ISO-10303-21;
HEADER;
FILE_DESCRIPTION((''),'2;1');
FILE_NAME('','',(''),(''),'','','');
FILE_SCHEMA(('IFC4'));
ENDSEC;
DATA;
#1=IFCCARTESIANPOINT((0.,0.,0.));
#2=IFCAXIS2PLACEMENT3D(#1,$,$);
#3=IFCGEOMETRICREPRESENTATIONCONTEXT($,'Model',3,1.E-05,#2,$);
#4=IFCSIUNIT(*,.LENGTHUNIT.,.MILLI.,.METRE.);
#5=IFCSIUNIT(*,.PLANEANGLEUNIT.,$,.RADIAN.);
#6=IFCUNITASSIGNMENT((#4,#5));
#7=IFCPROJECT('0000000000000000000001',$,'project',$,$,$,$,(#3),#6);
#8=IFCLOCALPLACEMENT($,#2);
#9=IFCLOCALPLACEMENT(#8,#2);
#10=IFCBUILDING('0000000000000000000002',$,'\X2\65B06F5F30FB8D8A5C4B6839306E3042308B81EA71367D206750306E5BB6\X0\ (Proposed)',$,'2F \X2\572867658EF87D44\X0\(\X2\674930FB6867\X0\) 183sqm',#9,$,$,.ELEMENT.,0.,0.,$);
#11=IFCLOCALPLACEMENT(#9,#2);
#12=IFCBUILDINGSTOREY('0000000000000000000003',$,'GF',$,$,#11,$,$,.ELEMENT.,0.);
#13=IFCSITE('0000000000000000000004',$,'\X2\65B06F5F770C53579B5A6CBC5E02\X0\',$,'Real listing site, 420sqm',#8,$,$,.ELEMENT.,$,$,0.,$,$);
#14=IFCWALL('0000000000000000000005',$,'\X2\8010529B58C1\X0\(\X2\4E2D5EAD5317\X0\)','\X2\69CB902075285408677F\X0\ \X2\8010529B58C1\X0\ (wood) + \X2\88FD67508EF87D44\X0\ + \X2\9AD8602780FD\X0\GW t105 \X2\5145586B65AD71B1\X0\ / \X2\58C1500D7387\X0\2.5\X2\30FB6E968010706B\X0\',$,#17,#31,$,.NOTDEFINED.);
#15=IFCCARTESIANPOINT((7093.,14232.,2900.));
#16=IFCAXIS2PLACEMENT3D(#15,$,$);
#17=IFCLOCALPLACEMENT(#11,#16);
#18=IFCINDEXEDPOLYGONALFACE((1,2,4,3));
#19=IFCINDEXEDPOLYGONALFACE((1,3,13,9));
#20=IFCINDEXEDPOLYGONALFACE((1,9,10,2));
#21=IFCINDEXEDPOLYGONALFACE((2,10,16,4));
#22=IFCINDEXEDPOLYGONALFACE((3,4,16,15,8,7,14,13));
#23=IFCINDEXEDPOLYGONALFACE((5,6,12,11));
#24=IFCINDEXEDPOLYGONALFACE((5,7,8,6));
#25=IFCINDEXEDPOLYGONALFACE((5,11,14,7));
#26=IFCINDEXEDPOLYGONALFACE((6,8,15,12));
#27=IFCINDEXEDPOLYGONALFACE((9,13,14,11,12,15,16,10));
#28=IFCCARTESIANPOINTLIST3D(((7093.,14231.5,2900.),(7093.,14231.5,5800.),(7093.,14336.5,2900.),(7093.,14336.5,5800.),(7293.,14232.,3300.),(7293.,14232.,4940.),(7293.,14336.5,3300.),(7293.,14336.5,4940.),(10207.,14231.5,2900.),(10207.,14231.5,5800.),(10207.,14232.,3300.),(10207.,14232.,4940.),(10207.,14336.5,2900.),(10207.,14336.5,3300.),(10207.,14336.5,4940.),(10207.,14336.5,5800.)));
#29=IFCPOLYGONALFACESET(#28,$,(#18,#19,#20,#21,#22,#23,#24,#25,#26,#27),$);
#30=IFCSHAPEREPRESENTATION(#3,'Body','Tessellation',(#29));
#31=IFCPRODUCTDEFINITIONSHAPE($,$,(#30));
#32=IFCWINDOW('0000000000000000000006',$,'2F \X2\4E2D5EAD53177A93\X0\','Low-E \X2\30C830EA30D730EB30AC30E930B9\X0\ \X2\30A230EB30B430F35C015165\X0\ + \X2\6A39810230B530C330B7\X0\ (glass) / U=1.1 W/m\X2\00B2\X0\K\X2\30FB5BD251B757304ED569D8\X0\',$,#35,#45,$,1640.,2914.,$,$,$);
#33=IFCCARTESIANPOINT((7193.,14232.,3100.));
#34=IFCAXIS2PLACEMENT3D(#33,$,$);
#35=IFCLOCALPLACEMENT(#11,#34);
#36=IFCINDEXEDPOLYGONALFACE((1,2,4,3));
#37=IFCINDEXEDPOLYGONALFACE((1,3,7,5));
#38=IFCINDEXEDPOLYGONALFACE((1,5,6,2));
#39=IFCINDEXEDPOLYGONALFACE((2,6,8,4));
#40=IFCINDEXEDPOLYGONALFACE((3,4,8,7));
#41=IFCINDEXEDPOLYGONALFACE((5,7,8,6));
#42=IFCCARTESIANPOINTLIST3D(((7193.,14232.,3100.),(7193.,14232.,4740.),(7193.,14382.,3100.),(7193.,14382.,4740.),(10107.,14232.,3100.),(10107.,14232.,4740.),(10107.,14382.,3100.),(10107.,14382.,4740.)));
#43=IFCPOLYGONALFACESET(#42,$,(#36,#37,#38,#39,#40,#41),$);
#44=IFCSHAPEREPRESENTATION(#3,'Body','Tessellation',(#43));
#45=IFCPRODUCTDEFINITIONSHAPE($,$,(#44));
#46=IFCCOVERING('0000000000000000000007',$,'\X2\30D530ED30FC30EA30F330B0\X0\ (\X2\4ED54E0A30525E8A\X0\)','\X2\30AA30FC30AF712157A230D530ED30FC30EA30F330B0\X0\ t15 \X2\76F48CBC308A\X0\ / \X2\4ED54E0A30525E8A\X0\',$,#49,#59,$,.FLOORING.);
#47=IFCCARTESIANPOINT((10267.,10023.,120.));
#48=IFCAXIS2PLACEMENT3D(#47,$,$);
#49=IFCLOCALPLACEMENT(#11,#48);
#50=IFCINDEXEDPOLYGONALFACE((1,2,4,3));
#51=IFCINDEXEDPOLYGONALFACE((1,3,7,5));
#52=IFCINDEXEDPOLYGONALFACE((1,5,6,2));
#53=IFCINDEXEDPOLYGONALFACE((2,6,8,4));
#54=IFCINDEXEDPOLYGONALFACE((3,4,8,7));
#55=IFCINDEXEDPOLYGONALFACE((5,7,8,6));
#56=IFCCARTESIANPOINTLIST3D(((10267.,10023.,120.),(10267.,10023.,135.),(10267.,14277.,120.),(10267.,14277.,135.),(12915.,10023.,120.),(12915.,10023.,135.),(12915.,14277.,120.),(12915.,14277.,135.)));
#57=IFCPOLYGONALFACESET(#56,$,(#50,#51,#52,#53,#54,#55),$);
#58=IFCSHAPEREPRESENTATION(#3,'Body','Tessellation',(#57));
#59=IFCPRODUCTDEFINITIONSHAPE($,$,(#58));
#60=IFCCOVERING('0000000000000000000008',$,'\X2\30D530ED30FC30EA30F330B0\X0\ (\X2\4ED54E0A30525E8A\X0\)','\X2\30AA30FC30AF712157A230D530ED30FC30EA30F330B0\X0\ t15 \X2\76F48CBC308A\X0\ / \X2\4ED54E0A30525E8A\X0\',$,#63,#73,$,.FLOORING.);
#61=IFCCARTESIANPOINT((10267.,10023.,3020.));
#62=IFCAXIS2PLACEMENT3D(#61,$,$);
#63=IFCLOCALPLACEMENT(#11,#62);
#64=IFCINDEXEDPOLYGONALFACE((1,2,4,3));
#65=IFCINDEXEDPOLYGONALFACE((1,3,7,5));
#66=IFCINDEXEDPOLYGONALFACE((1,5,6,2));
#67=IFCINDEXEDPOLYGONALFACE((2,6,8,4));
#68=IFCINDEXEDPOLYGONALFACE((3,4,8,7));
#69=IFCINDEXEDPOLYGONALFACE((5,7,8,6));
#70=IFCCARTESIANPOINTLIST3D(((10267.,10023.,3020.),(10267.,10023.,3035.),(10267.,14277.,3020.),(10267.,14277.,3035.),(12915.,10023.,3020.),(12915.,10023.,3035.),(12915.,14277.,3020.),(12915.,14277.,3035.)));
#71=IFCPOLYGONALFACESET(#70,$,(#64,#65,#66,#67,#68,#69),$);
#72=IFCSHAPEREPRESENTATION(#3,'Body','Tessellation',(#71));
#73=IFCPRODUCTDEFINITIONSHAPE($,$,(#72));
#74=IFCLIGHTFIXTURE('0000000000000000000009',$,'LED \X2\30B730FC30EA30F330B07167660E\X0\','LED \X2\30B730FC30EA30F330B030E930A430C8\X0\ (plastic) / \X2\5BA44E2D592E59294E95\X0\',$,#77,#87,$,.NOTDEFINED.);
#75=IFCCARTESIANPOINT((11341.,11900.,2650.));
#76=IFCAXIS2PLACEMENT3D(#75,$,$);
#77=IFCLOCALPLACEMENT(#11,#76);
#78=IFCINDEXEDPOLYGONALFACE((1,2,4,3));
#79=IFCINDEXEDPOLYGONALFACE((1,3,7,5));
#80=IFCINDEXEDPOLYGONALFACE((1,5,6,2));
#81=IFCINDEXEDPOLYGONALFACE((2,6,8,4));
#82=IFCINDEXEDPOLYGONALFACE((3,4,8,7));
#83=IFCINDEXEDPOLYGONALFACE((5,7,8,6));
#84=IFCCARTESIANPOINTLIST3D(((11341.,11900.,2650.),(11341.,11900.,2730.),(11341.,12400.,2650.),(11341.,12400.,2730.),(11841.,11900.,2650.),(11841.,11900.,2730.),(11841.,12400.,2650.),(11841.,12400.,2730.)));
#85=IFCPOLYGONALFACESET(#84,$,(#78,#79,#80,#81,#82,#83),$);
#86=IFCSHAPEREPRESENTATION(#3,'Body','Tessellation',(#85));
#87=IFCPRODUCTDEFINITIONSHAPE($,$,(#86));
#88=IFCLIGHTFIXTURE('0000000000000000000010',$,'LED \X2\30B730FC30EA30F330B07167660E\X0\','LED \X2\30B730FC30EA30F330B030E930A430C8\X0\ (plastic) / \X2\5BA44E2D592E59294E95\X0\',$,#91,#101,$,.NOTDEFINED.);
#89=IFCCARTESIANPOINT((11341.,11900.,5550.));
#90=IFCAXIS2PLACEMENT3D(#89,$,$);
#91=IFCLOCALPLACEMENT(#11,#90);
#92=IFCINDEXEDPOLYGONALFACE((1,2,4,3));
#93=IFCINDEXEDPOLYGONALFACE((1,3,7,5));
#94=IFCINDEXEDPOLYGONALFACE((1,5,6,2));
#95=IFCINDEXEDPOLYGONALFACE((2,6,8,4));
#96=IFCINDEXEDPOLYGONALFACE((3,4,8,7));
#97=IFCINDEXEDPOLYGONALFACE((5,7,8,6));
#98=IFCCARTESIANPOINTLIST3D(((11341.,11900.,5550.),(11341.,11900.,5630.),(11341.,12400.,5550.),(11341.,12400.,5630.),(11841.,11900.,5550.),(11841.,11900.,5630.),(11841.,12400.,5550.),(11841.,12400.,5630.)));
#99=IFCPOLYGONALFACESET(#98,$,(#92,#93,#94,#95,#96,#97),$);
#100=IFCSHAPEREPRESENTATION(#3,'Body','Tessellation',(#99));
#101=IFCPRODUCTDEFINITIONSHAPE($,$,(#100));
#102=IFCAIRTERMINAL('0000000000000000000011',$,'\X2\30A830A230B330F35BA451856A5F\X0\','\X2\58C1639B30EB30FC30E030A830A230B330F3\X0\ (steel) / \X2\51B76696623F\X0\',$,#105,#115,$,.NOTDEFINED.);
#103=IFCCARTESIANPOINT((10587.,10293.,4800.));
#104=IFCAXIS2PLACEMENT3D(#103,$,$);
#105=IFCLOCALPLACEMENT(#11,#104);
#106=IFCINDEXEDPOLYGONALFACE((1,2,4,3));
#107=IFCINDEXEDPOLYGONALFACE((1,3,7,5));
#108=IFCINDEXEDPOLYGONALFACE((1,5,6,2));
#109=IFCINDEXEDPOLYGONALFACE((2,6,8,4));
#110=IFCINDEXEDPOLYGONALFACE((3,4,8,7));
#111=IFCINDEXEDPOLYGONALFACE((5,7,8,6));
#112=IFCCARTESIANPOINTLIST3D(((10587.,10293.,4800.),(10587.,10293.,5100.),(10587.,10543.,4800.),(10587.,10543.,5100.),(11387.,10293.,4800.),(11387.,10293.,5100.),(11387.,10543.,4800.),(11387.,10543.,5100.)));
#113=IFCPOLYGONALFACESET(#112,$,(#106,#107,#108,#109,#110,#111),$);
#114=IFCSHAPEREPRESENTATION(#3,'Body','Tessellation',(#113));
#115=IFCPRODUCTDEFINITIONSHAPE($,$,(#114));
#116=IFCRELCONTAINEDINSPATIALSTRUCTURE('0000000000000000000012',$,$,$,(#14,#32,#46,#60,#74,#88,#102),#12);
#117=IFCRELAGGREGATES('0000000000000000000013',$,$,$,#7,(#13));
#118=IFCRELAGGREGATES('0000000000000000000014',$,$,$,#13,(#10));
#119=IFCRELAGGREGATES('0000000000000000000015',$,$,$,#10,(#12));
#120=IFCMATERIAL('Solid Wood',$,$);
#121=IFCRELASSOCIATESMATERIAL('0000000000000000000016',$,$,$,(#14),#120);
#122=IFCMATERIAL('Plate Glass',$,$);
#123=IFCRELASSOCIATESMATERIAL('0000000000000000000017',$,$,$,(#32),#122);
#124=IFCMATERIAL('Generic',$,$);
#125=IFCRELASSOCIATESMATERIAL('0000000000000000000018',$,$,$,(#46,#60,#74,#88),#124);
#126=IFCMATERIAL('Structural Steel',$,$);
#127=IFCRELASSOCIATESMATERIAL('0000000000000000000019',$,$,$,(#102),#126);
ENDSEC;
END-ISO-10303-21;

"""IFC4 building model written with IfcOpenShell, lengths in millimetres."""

from ifc_helpers import new_model, si_unit, frame, frame_2d, origin, place, context, project, spatial, rectangle, extrude, material, element, fill, save


model = new_model("IFC4")

# Units and contexts
model_context = context("Model", 3, precision=1e-05, world=origin())
ifc_project = project(units=[si_unit("LENGTHUNIT", "METRE", prefix="MILLI"), si_unit("PLANEANGLEUNIT", "RADIAN")], contexts=[model_context])

# Site, building, storey
site_placement = place(None, origin())
site = spatial("IfcSite", under=ifc_project, at=site_placement, Name="新潟県南魚沼市", ObjectType="Real listing site, 420sqm", CompositionType="ELEMENT", RefElevation=0.0)
building_placement = place(site_placement, origin())
building = spatial("IfcBuilding", under=site, at=building_placement, Name="新潟・越屋根のある自然素材の家 (Proposed)", ObjectType="2F 在来軸組(杉・桧) 183sqm", CompositionType="ELEMENT", ElevationOfRefHeight=0.0, ElevationOfTerrain=0.0)
storey_placement = place(building_placement, origin())
storey = spatial("IfcBuildingStorey", under=building, at=storey_placement, Name="GF", CompositionType="ELEMENT", Elevation=0.0)

# Shared definitions
ifc_material_1 = material(Name="Solid Wood")

# Wall, opening, window
ifc_material_2 = material(Name="Plate Glass")
wall_1_placement = place(storey_placement, frame((7093.0, 14232.0, 2900.0)))
wall_1 = element("IfcWall", 1, at=wall_1_placement, inside=storey, material=ifc_material_1, Name="耐力壁(中庭北)", Description="構造用合板 耐力壁 (wood) + 製材軸組 + 高性能GW t105 充填断熱 / 壁倍率2.5・準耐火", PredefinedType="NOTDEFINED", context=model_context, shape_type="SweptSolid", body=[
    extrude(rectangle(XDim=3114.0, YDim=105.0, at=frame_2d((1557.0, 52.0))), frame((7093.0, 14232.0, 2900.0)), (0.0, 0.0, 1.0), 2900.0),
])
opening_1_placement = place(storey_placement, frame((7193.0, 14232.0, 3100.0)))
opening_1 = element("IfcOpeningElement", 2, at=opening_1_placement, cuts=wall_1, PredefinedType="NOTDEFINED", context=model_context, shape_type="SweptSolid", body=[
    extrude(rectangle(XDim=2914.0, YDim=150.0, at=frame_2d((1457.0, 75.0))), frame((7193.0, 14232.0, 3100.0)), (0.0, 0.0, 1.0), 1640.0),
])
window_1_placement = place(storey_placement, frame((7193.0, 14232.0, 3100.0)))
window_1 = element("IfcWindow", 3, at=window_1_placement, inside=storey, material=ifc_material_2, Name="2F 中庭北窓", Description="Low-E トリプルガラス アルゴン封入 + 樹脂サッシ (glass) / U=1.1 W/m²K・寒冷地仕様", OverallHeight=1640.0, OverallWidth=2914.0, context=model_context, shape_type="SweptSolid", body=[
    extrude(rectangle(XDim=2914.0, YDim=150.0, at=frame_2d((1457.0, 75.0))), frame((7193.0, 14232.0, 3100.0)), (0.0, 0.0, 1.0), 1640.0),
])
fill(opening_1, window_1)

# Coverings
ifc_material_3 = material(Name="Generic")
covering_1_placement = place(storey_placement, frame((10267.0, 10023.0, 120.0)))
element("IfcCovering", 4, at=covering_1_placement, inside=storey, material=ifc_material_3, Name="フローリング (仕上げ床)", Description="オーク無垢フローリング t15 直貼り / 仕上げ床", PredefinedType="FLOORING", context=model_context, shape_type="SweptSolid", body=[
    extrude(rectangle(XDim=2648.0, YDim=4254.0, at=frame_2d((1324.0, 2127.0))), frame((10267.0, 10023.0, 120.0)), (0.0, 0.0, 1.0), 15.0),
])
covering_2_placement = place(storey_placement, frame((10267.0, 10023.0, 3020.0)))
element("IfcCovering", 5, at=covering_2_placement, inside=storey, material=ifc_material_3, Name="フローリング (仕上げ床)", Description="オーク無垢フローリング t15 直貼り / 仕上げ床", PredefinedType="FLOORING", context=model_context, shape_type="SweptSolid", body=[
    extrude(rectangle(XDim=2648.0, YDim=4254.0, at=frame_2d((1324.0, 2127.0))), frame((10267.0, 10023.0, 3020.0)), (0.0, 0.0, 1.0), 15.0),
])

# Light fixtures
light_fixture_1_placement = place(storey_placement, frame((11341.0, 11900.0, 2650.0)))
element("IfcLightFixture", 6, at=light_fixture_1_placement, inside=storey, material=ifc_material_3, Name="LED シーリング照明", Description="LED シーリングライト (plastic) / 室中央天井", PredefinedType="NOTDEFINED", context=model_context, shape_type="SweptSolid", body=[
    extrude(rectangle(XDim=500.0, YDim=500.0, at=frame_2d((250.0, 250.0))), frame((11341.0, 11900.0, 2650.0)), (0.0, 0.0, 1.0), 80.0),
])
light_fixture_2_placement = place(storey_placement, frame((11341.0, 11900.0, 5550.0)))
element("IfcLightFixture", 7, at=light_fixture_2_placement, inside=storey, material=ifc_material_3, Name="LED シーリング照明", Description="LED シーリングライト (plastic) / 室中央天井", PredefinedType="NOTDEFINED", context=model_context, shape_type="SweptSolid", body=[
    extrude(rectangle(XDim=500.0, YDim=500.0, at=frame_2d((250.0, 250.0))), frame((11341.0, 11900.0, 5550.0)), (0.0, 0.0, 1.0), 80.0),
])

# Air terminal
ifc_material_4 = material(Name="Structural Steel")
air_terminal_placement = place(storey_placement, frame((10587.0, 10293.0, 4800.0)))
element("IfcAirTerminal", 8, at=air_terminal_placement, inside=storey, material=ifc_material_4, Name="エアコン室内機", Description="壁掛ルームエアコン (steel) / 冷暖房", PredefinedType="NOTDEFINED", context=model_context, shape_type="SweptSolid", body=[
    extrude(rectangle(XDim=800.0, YDim=250.0, at=frame_2d((400.0, 125.0))), frame((10587.0, 10293.0, 4800.0)), (0.0, 0.0, 1.0), 300.0),
])

save(model, "model.ifc")
